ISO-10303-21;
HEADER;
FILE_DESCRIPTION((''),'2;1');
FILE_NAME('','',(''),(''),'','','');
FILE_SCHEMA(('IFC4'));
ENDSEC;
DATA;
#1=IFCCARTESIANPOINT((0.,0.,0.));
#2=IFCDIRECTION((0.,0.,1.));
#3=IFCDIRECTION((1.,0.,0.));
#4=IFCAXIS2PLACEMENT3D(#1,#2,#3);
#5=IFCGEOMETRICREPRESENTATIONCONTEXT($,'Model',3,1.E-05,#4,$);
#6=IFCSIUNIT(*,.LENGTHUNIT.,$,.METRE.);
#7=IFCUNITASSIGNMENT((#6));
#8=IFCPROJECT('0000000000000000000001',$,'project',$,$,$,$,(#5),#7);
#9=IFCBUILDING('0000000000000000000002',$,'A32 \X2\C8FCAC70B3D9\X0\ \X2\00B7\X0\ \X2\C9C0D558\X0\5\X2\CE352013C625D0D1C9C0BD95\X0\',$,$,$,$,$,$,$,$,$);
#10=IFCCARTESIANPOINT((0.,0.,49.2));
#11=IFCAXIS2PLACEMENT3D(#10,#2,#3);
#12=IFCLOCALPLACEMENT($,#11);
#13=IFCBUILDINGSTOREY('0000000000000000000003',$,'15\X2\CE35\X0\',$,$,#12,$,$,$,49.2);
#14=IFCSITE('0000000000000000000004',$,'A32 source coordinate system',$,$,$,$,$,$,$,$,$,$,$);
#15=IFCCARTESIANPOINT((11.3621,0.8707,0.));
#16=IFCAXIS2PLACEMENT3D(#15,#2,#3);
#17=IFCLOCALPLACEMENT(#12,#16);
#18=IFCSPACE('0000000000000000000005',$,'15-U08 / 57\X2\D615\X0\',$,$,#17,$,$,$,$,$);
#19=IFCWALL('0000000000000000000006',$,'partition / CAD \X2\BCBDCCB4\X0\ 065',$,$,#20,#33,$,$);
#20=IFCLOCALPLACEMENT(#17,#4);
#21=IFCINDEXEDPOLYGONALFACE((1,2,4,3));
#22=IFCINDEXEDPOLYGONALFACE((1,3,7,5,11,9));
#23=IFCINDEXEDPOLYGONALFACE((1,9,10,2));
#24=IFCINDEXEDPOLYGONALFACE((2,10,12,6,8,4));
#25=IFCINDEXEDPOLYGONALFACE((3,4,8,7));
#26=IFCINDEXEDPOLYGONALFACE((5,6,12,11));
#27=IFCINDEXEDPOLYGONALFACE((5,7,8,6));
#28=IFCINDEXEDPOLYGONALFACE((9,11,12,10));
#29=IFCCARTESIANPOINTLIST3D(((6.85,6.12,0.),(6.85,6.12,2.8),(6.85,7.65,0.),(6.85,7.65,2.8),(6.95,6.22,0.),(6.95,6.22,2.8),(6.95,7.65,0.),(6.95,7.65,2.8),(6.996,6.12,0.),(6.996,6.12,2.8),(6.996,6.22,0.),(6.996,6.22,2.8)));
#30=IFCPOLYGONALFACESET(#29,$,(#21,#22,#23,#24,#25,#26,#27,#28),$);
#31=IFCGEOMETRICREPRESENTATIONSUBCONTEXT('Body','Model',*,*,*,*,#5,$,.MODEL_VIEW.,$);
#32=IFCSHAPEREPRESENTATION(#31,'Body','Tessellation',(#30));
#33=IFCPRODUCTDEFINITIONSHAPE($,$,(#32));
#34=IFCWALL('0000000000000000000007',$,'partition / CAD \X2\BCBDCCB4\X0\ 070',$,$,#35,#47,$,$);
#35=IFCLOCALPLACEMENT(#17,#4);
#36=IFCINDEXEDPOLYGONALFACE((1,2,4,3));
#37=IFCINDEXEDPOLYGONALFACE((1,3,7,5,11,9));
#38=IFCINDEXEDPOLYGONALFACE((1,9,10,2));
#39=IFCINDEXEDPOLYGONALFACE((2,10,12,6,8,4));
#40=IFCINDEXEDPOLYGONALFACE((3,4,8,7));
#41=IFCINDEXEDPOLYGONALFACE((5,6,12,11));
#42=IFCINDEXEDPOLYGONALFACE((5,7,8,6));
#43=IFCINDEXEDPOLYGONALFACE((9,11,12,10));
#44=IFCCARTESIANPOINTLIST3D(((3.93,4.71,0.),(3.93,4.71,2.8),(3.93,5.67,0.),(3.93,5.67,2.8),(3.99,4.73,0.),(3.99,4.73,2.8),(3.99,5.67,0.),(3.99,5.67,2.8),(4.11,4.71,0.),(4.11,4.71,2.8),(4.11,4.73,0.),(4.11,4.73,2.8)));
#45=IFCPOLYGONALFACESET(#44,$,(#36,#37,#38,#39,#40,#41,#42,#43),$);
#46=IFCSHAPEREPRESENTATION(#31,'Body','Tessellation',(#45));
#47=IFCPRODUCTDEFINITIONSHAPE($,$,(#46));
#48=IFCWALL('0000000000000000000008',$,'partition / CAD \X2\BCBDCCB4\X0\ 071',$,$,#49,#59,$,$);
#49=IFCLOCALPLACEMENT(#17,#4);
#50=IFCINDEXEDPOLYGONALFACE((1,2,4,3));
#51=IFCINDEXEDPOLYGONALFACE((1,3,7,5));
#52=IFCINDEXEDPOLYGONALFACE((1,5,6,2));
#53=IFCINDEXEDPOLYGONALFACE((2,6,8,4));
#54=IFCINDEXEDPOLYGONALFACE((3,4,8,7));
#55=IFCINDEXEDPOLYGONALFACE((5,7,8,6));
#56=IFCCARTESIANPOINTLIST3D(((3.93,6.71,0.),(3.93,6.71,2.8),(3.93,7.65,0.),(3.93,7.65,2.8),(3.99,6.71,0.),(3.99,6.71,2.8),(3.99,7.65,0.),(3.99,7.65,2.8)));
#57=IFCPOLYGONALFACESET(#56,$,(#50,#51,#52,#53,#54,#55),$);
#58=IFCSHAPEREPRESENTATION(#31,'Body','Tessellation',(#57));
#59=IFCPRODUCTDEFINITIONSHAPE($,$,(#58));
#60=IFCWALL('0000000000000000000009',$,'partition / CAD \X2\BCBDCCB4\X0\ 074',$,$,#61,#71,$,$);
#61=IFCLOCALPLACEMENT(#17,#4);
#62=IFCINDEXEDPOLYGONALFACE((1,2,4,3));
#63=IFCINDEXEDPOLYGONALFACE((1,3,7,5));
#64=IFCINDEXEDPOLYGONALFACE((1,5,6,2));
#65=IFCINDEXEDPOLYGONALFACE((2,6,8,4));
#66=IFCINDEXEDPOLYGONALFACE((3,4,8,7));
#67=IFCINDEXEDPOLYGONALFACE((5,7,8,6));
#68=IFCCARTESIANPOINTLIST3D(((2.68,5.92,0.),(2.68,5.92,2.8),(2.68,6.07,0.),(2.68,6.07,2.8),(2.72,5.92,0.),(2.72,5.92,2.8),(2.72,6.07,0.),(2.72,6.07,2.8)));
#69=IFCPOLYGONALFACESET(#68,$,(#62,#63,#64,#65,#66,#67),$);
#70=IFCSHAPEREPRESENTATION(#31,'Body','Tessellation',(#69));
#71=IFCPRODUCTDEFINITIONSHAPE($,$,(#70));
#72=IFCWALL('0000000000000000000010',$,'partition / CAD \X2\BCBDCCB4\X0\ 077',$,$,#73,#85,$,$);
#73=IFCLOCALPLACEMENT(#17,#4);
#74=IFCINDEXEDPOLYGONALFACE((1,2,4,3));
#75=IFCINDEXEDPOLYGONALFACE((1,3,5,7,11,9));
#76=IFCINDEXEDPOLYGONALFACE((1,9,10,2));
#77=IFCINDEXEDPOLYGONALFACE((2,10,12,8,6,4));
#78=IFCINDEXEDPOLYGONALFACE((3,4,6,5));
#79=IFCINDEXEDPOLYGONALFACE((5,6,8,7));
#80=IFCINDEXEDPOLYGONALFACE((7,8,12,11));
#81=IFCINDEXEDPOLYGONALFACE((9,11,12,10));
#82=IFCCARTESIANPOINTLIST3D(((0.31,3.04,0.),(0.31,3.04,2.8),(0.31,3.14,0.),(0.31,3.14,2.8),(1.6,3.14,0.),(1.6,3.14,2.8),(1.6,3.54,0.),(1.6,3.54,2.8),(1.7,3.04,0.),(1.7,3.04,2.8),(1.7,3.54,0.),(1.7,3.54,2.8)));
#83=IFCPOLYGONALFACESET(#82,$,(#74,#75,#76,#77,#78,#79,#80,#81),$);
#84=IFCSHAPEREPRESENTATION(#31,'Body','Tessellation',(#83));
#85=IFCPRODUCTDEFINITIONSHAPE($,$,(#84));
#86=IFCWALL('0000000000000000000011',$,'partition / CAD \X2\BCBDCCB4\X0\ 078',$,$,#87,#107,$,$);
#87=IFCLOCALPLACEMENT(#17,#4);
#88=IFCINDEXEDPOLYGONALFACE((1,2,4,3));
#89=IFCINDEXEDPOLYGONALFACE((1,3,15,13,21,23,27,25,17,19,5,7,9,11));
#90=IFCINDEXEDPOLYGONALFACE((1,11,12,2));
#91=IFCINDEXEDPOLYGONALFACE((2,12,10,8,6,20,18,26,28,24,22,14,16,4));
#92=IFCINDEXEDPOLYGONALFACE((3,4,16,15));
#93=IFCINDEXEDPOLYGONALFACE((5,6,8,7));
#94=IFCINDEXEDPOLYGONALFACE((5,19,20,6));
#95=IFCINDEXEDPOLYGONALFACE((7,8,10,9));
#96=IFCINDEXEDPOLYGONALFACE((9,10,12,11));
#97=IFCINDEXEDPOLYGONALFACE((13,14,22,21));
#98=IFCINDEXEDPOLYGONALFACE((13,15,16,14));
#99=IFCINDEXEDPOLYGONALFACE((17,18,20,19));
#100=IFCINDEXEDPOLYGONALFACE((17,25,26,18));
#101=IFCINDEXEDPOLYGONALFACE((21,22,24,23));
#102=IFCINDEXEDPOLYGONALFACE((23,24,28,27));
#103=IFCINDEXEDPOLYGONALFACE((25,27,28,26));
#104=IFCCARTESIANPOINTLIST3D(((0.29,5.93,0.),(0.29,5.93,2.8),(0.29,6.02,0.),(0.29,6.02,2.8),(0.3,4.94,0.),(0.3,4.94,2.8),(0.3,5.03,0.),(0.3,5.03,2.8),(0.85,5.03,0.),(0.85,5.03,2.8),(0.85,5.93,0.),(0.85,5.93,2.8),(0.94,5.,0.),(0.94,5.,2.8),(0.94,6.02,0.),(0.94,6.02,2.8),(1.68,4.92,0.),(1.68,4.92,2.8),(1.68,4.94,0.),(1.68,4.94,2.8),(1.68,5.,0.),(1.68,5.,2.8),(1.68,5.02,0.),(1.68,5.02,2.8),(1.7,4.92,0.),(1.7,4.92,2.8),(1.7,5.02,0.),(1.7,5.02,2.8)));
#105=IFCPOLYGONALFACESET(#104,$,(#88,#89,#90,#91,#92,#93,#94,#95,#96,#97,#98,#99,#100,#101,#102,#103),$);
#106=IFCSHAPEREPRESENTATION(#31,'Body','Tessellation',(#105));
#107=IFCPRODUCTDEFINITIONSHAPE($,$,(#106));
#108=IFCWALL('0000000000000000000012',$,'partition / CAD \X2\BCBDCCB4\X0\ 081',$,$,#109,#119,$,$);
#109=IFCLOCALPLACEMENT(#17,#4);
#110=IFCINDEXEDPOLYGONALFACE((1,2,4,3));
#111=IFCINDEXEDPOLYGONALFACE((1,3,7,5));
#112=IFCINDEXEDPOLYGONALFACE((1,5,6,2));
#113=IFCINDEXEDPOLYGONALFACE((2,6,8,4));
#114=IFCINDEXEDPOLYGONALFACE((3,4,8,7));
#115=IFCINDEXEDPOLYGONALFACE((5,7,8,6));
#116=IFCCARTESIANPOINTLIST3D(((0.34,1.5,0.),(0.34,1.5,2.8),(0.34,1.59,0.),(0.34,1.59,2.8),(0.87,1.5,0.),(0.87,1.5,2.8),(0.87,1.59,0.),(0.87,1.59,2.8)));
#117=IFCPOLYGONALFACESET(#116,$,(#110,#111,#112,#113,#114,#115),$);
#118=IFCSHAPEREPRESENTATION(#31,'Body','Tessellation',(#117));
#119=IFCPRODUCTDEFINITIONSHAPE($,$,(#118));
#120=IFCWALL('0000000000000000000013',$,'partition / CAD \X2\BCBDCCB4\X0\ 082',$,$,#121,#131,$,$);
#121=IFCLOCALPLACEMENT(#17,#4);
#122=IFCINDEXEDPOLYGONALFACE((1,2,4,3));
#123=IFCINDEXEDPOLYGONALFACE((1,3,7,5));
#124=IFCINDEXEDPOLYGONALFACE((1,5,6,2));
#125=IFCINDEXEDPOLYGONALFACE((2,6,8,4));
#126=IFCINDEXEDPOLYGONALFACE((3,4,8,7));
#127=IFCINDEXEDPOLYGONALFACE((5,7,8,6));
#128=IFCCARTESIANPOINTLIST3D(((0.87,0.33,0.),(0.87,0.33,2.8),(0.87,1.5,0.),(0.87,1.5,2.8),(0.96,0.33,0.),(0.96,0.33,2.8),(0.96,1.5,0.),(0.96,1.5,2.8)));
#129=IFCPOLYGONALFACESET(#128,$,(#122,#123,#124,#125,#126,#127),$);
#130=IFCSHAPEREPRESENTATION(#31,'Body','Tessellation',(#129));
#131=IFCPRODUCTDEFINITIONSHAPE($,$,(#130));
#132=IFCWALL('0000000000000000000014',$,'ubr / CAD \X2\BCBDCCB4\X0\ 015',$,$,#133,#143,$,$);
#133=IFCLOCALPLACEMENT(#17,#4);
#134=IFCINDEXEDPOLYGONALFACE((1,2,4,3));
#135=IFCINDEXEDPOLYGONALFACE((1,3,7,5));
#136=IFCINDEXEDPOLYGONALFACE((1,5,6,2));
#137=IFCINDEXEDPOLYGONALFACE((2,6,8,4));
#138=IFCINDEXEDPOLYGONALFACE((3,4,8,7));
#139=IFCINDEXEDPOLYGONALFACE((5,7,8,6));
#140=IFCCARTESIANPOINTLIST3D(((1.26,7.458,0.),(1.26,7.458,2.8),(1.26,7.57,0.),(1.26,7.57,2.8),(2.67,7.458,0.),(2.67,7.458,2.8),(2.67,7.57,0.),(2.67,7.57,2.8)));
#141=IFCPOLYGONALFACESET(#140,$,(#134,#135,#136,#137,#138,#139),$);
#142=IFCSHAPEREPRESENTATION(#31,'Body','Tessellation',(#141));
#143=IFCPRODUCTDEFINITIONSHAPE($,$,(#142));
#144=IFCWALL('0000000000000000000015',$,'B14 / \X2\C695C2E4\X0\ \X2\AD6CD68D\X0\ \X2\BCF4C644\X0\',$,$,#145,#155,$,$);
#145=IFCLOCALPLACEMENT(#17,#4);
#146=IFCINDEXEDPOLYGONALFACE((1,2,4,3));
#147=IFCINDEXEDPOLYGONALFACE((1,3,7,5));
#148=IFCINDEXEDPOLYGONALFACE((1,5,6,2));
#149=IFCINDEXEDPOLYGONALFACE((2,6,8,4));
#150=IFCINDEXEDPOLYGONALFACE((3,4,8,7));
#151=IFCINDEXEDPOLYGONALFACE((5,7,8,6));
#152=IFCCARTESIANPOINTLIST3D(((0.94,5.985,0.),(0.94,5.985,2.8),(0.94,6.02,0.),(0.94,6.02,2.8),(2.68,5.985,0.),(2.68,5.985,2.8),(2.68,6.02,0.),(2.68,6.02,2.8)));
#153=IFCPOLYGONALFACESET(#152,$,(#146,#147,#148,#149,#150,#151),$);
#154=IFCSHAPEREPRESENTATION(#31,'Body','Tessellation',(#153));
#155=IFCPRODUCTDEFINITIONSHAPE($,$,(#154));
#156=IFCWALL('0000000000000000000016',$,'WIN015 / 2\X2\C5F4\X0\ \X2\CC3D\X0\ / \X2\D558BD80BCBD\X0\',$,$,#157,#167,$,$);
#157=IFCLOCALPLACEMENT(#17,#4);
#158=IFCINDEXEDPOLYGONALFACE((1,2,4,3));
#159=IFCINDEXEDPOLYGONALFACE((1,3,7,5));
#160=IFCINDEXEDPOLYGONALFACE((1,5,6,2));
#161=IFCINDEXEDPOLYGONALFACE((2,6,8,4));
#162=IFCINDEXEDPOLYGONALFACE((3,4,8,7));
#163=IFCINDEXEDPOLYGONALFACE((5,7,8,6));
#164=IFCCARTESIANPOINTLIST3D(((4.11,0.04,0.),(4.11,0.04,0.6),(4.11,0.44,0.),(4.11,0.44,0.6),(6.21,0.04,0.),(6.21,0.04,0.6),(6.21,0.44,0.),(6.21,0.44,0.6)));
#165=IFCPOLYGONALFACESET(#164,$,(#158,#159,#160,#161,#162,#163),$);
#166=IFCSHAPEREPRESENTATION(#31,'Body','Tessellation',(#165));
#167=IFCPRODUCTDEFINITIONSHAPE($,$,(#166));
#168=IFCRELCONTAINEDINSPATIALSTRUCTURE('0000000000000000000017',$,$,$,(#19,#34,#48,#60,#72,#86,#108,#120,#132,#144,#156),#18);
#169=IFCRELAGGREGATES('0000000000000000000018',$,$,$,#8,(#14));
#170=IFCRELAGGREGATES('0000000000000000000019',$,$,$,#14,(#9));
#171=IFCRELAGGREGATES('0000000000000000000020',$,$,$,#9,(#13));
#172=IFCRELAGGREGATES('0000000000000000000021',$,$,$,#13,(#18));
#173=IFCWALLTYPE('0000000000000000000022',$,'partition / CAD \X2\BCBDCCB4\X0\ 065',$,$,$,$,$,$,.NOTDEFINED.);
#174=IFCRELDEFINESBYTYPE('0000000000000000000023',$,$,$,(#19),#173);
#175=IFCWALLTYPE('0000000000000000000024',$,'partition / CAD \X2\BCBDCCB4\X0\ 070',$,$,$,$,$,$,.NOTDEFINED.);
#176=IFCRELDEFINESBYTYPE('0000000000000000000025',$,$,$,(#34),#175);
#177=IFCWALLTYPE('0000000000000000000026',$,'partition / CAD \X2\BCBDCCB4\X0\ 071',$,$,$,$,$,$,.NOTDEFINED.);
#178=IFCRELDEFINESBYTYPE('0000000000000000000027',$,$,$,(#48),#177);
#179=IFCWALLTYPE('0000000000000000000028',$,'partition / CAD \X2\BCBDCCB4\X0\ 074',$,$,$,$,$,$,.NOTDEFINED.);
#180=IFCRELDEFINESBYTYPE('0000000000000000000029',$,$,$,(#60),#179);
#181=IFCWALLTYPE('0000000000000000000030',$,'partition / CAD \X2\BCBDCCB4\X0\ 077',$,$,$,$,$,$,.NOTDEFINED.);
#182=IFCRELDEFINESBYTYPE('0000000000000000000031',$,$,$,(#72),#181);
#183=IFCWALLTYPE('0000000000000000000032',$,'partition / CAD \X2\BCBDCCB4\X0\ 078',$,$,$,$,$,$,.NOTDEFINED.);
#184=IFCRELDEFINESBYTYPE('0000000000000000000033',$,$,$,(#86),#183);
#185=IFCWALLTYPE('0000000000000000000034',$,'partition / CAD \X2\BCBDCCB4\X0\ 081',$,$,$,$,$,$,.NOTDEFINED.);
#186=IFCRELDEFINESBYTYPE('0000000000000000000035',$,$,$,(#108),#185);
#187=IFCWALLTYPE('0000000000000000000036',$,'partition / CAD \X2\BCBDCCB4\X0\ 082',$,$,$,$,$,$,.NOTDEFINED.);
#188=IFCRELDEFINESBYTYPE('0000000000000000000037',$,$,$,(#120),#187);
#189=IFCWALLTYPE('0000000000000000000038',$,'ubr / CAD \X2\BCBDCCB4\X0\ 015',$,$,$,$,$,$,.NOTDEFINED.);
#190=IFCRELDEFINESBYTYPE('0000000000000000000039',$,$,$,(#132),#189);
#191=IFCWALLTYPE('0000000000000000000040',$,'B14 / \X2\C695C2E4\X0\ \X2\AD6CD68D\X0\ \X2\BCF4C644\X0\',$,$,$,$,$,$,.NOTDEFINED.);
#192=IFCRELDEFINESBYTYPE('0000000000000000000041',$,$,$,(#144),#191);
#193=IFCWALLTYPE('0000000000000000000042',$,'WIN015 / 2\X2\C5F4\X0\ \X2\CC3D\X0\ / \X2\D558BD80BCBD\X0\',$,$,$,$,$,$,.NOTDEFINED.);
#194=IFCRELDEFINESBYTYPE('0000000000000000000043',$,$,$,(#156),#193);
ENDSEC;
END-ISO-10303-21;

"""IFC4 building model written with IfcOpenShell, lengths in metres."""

from ifc_helpers import new_model, si_unit, frame, origin, origin_with_axes, place, context, subcontext, project, spatial, polyline, outline, extrude, source, transform, mapped, type_object, type_shapes, element, save


model = new_model("IFC4")

# Units and contexts
model_context = context("Model", 3, precision=1e-05, world=origin_with_axes())
body_context = subcontext(model_context, "Body", "Model", "MODEL_VIEW")
ifc_project = project(units=[si_unit("LENGTHUNIT", "METRE")], contexts=[model_context])

# Site, building, storey, space
storey_placement = place(None, frame((0.0, 0.0, 49.2), z_axis=(0.0, 0.0, 1.0), x_axis=(1.0, 0.0, 0.0)))
space_placement = place(storey_placement, frame((11.3621, 0.8707, 0.0), z_axis=(0.0, 0.0, 1.0), x_axis=(1.0, 0.0, 0.0)))
site = spatial("IfcSite", under=ifc_project, Name="A32 source coordinate system")
building = spatial("IfcBuilding", under=site, Name="A32 주거동 · 지하5층–옥탑지붕")
storey = spatial("IfcBuildingStorey", under=building, at=storey_placement, Name="15층", Elevation=49.2)
space = spatial("IfcSpace", under=storey, at=space_placement, Name="15-U08 / 57형")

# Walls
wall_type_1 = type_object("IfcWallType", Name="partition / CAD 벽체 065", PredefinedType="NOTDEFINED")
shared_shape_1 = source(origin(), body_context, "Body", "SweptSolid", [
    extrude(outline(polyline([(6.95, 7.65), (6.95, 6.22), (6.996, 6.22), (6.996, 6.12), (6.85, 6.12), (6.85, 7.65), (6.95, 7.65)])), origin(), (0.0, 0.0, 1.0), 2.8),
])
type_shapes(wall_type_1, [shared_shape_1])
wall_1_placement = place(space_placement, origin_with_axes())
element("IfcWall", 1, at=wall_1_placement, inside=space, type_object=wall_type_1, Name="partition / CAD 벽체 065", context=body_context, shape_type="MappedRepresentation", body=[
    mapped(shared_shape_1, transform((0.0, 0.0, 0.0), scale=1.0)),
])
wall_type_2 = type_object("IfcWallType", Name="partition / CAD 벽체 070", PredefinedType="NOTDEFINED")
shared_shape_2 = source(origin(), body_context, "Body", "SweptSolid", [
    extrude(outline(polyline([(4.11, 4.73), (4.11, 4.71), (3.93, 4.71), (3.93, 5.67), (3.99, 5.67), (3.99, 4.73), (4.11, 4.73)])), origin(), (0.0, 0.0, 1.0), 2.8),
])
type_shapes(wall_type_2, [shared_shape_2])
wall_2_placement = place(space_placement, origin_with_axes())
element("IfcWall", 2, at=wall_2_placement, inside=space, type_object=wall_type_2, Name="partition / CAD 벽체 070", context=body_context, shape_type="MappedRepresentation", body=[
    mapped(shared_shape_2, transform((0.0, 0.0, 0.0), scale=1.0)),
])
wall_type_3 = type_object("IfcWallType", Name="partition / CAD 벽체 071", PredefinedType="NOTDEFINED")
shared_shape_3 = source(origin(), body_context, "Body", "SweptSolid", [
    extrude(outline(polyline([(3.93, 6.71), (3.93, 7.65), (3.99, 7.65), (3.99, 6.71), (3.93, 6.71)])), origin(), (0.0, 0.0, 1.0), 2.8),
])
type_shapes(wall_type_3, [shared_shape_3])
wall_3_placement = place(space_placement, origin_with_axes())
element("IfcWall", 3, at=wall_3_placement, inside=space, type_object=wall_type_3, Name="partition / CAD 벽체 071", context=body_context, shape_type="MappedRepresentation", body=[
    mapped(shared_shape_3, transform((0.0, 0.0, 0.0), scale=1.0)),
])
wall_type_4 = type_object("IfcWallType", Name="partition / CAD 벽체 074", PredefinedType="NOTDEFINED")
shared_shape_4 = source(origin(), body_context, "Body", "SweptSolid", [
    extrude(outline(polyline([(2.72, 6.07), (2.72, 5.92), (2.68, 5.92), (2.68, 6.07), (2.72, 6.07)])), origin(), (0.0, 0.0, 1.0), 2.8),
])
type_shapes(wall_type_4, [shared_shape_4])
wall_4_placement = place(space_placement, origin_with_axes())
element("IfcWall", 4, at=wall_4_placement, inside=space, type_object=wall_type_4, Name="partition / CAD 벽체 074", context=body_context, shape_type="MappedRepresentation", body=[
    mapped(shared_shape_4, transform((0.0, 0.0, 0.0), scale=1.0)),
])
wall_type_5 = type_object("IfcWallType", Name="partition / CAD 벽체 077", PredefinedType="NOTDEFINED")
shared_shape_5 = source(origin(), body_context, "Body", "SweptSolid", [
    extrude(outline(polyline([(1.7, 3.54), (1.7, 3.04), (0.31, 3.04), (0.31, 3.14), (1.6, 3.14), (1.6, 3.54), (1.7, 3.54)])), origin(), (0.0, 0.0, 1.0), 2.8),
])
type_shapes(wall_type_5, [shared_shape_5])
wall_5_placement = place(space_placement, origin_with_axes())
element("IfcWall", 5, at=wall_5_placement, inside=space, type_object=wall_type_5, Name="partition / CAD 벽체 077", context=body_context, shape_type="MappedRepresentation", body=[
    mapped(shared_shape_5, transform((0.0, 0.0, 0.0), scale=1.0)),
])
wall_type_6 = type_object("IfcWallType", Name="partition / CAD 벽체 078", PredefinedType="NOTDEFINED")
shared_shape_6 = source(origin(), body_context, "Body", "SweptSolid", [
    extrude(outline(polyline([(1.7, 4.92), (1.68, 4.92), (1.68, 4.94), (0.3, 4.94), (0.3, 5.03), (0.85, 5.03), (0.85, 5.93), (0.29, 5.93), (0.29, 6.02), (0.94, 6.02), (0.94, 5.0), (1.68, 5.0), (1.68, 5.02), (1.7, 5.02), (1.7, 4.92)])), origin(), (0.0, 0.0, 1.0), 2.8),
])
type_shapes(wall_type_6, [shared_shape_6])
wall_6_placement = place(space_placement, origin_with_axes())
element("IfcWall", 6, at=wall_6_placement, inside=space, type_object=wall_type_6, Name="partition / CAD 벽체 078", context=body_context, shape_type="MappedRepresentation", body=[
    mapped(shared_shape_6, transform((0.0, 0.0, 0.0), scale=1.0)),
])
wall_type_7 = type_object("IfcWallType", Name="partition / CAD 벽체 081", PredefinedType="NOTDEFINED")
shared_shape_7 = source(origin(), body_context, "Body", "SweptSolid", [
    extrude(outline(polyline([(0.34, 1.59), (0.87, 1.59), (0.87, 1.5), (0.34, 1.5), (0.34, 1.59)])), origin(), (0.0, 0.0, 1.0), 2.8),
])
type_shapes(wall_type_7, [shared_shape_7])
wall_7_placement = place(space_placement, origin_with_axes())
element("IfcWall", 7, at=wall_7_placement, inside=space, type_object=wall_type_7, Name="partition / CAD 벽체 081", context=body_context, shape_type="MappedRepresentation", body=[
    mapped(shared_shape_7, transform((0.0, 0.0, 0.0), scale=1.0)),
])
wall_type_8 = type_object("IfcWallType", Name="partition / CAD 벽체 082", PredefinedType="NOTDEFINED")
shared_shape_8 = source(origin(), body_context, "Body", "SweptSolid", [
    extrude(outline(polyline([(0.96, 0.33), (0.87, 0.33), (0.87, 1.5), (0.96, 1.5), (0.96, 0.33)])), origin(), (0.0, 0.0, 1.0), 2.8),
])
type_shapes(wall_type_8, [shared_shape_8])
wall_8_placement = place(space_placement, origin_with_axes())
element("IfcWall", 8, at=wall_8_placement, inside=space, type_object=wall_type_8, Name="partition / CAD 벽체 082", context=body_context, shape_type="MappedRepresentation", body=[
    mapped(shared_shape_8, transform((0.0, 0.0, 0.0), scale=1.0)),
])
wall_type_9 = type_object("IfcWallType", Name="ubr / CAD 벽체 015", PredefinedType="NOTDEFINED")
shared_shape_9 = source(origin(), body_context, "Body", "SweptSolid", [
    extrude(outline(polyline([(2.67, 7.57), (2.67, 7.458), (1.26, 7.458), (1.26, 7.57), (2.67, 7.57)])), origin(), (0.0, 0.0, 1.0), 2.8),
])
type_shapes(wall_type_9, [shared_shape_9])
wall_9_placement = place(space_placement, origin_with_axes())
element("IfcWall", 9, at=wall_9_placement, inside=space, type_object=wall_type_9, Name="ubr / CAD 벽체 015", context=body_context, shape_type="MappedRepresentation", body=[
    mapped(shared_shape_9, transform((0.0, 0.0, 0.0), scale=1.0)),
])
wall_type_10 = type_object("IfcWallType", Name="B14 / 욕실 구획 보완", PredefinedType="NOTDEFINED")
shared_shape_10 = source(origin(), body_context, "Body", "SweptSolid", [
    extrude(outline(polyline([(2.68, 5.985), (0.94, 5.985), (0.94, 6.02), (2.68, 6.02), (2.68, 5.985)])), origin(), (0.0, 0.0, 1.0), 2.8),
])
type_shapes(wall_type_10, [shared_shape_10])
wall_10_placement = place(space_placement, origin_with_axes())
element("IfcWall", 10, at=wall_10_placement, inside=space, type_object=wall_type_10, Name="B14 / 욕실 구획 보완", context=body_context, shape_type="MappedRepresentation", body=[
    mapped(shared_shape_10, transform((0.0, 0.0, 0.0), scale=1.0)),
])
wall_type_11 = type_object("IfcWallType", Name="WIN015 / 2열 창 / 하부벽", PredefinedType="NOTDEFINED")
shared_shape_11 = source(origin(), body_context, "Body", "SweptSolid", [
    extrude(outline(polyline([(4.11, 0.04), (4.11, 0.44), (6.21, 0.44), (6.21, 0.04), (4.11, 0.04)])), origin(), (0.0, 0.0, 1.0), 0.6),
])
type_shapes(wall_type_11, [shared_shape_11])
wall_11_placement = place(space_placement, origin_with_axes())
element("IfcWall", 11, at=wall_11_placement, inside=space, type_object=wall_type_11, Name="WIN015 / 2열 창 / 하부벽", context=body_context, shape_type="MappedRepresentation", body=[
    mapped(shared_shape_11, transform((0.0, 0.0, 0.0), scale=1.0)),
])

save(model, "model.ifc")
